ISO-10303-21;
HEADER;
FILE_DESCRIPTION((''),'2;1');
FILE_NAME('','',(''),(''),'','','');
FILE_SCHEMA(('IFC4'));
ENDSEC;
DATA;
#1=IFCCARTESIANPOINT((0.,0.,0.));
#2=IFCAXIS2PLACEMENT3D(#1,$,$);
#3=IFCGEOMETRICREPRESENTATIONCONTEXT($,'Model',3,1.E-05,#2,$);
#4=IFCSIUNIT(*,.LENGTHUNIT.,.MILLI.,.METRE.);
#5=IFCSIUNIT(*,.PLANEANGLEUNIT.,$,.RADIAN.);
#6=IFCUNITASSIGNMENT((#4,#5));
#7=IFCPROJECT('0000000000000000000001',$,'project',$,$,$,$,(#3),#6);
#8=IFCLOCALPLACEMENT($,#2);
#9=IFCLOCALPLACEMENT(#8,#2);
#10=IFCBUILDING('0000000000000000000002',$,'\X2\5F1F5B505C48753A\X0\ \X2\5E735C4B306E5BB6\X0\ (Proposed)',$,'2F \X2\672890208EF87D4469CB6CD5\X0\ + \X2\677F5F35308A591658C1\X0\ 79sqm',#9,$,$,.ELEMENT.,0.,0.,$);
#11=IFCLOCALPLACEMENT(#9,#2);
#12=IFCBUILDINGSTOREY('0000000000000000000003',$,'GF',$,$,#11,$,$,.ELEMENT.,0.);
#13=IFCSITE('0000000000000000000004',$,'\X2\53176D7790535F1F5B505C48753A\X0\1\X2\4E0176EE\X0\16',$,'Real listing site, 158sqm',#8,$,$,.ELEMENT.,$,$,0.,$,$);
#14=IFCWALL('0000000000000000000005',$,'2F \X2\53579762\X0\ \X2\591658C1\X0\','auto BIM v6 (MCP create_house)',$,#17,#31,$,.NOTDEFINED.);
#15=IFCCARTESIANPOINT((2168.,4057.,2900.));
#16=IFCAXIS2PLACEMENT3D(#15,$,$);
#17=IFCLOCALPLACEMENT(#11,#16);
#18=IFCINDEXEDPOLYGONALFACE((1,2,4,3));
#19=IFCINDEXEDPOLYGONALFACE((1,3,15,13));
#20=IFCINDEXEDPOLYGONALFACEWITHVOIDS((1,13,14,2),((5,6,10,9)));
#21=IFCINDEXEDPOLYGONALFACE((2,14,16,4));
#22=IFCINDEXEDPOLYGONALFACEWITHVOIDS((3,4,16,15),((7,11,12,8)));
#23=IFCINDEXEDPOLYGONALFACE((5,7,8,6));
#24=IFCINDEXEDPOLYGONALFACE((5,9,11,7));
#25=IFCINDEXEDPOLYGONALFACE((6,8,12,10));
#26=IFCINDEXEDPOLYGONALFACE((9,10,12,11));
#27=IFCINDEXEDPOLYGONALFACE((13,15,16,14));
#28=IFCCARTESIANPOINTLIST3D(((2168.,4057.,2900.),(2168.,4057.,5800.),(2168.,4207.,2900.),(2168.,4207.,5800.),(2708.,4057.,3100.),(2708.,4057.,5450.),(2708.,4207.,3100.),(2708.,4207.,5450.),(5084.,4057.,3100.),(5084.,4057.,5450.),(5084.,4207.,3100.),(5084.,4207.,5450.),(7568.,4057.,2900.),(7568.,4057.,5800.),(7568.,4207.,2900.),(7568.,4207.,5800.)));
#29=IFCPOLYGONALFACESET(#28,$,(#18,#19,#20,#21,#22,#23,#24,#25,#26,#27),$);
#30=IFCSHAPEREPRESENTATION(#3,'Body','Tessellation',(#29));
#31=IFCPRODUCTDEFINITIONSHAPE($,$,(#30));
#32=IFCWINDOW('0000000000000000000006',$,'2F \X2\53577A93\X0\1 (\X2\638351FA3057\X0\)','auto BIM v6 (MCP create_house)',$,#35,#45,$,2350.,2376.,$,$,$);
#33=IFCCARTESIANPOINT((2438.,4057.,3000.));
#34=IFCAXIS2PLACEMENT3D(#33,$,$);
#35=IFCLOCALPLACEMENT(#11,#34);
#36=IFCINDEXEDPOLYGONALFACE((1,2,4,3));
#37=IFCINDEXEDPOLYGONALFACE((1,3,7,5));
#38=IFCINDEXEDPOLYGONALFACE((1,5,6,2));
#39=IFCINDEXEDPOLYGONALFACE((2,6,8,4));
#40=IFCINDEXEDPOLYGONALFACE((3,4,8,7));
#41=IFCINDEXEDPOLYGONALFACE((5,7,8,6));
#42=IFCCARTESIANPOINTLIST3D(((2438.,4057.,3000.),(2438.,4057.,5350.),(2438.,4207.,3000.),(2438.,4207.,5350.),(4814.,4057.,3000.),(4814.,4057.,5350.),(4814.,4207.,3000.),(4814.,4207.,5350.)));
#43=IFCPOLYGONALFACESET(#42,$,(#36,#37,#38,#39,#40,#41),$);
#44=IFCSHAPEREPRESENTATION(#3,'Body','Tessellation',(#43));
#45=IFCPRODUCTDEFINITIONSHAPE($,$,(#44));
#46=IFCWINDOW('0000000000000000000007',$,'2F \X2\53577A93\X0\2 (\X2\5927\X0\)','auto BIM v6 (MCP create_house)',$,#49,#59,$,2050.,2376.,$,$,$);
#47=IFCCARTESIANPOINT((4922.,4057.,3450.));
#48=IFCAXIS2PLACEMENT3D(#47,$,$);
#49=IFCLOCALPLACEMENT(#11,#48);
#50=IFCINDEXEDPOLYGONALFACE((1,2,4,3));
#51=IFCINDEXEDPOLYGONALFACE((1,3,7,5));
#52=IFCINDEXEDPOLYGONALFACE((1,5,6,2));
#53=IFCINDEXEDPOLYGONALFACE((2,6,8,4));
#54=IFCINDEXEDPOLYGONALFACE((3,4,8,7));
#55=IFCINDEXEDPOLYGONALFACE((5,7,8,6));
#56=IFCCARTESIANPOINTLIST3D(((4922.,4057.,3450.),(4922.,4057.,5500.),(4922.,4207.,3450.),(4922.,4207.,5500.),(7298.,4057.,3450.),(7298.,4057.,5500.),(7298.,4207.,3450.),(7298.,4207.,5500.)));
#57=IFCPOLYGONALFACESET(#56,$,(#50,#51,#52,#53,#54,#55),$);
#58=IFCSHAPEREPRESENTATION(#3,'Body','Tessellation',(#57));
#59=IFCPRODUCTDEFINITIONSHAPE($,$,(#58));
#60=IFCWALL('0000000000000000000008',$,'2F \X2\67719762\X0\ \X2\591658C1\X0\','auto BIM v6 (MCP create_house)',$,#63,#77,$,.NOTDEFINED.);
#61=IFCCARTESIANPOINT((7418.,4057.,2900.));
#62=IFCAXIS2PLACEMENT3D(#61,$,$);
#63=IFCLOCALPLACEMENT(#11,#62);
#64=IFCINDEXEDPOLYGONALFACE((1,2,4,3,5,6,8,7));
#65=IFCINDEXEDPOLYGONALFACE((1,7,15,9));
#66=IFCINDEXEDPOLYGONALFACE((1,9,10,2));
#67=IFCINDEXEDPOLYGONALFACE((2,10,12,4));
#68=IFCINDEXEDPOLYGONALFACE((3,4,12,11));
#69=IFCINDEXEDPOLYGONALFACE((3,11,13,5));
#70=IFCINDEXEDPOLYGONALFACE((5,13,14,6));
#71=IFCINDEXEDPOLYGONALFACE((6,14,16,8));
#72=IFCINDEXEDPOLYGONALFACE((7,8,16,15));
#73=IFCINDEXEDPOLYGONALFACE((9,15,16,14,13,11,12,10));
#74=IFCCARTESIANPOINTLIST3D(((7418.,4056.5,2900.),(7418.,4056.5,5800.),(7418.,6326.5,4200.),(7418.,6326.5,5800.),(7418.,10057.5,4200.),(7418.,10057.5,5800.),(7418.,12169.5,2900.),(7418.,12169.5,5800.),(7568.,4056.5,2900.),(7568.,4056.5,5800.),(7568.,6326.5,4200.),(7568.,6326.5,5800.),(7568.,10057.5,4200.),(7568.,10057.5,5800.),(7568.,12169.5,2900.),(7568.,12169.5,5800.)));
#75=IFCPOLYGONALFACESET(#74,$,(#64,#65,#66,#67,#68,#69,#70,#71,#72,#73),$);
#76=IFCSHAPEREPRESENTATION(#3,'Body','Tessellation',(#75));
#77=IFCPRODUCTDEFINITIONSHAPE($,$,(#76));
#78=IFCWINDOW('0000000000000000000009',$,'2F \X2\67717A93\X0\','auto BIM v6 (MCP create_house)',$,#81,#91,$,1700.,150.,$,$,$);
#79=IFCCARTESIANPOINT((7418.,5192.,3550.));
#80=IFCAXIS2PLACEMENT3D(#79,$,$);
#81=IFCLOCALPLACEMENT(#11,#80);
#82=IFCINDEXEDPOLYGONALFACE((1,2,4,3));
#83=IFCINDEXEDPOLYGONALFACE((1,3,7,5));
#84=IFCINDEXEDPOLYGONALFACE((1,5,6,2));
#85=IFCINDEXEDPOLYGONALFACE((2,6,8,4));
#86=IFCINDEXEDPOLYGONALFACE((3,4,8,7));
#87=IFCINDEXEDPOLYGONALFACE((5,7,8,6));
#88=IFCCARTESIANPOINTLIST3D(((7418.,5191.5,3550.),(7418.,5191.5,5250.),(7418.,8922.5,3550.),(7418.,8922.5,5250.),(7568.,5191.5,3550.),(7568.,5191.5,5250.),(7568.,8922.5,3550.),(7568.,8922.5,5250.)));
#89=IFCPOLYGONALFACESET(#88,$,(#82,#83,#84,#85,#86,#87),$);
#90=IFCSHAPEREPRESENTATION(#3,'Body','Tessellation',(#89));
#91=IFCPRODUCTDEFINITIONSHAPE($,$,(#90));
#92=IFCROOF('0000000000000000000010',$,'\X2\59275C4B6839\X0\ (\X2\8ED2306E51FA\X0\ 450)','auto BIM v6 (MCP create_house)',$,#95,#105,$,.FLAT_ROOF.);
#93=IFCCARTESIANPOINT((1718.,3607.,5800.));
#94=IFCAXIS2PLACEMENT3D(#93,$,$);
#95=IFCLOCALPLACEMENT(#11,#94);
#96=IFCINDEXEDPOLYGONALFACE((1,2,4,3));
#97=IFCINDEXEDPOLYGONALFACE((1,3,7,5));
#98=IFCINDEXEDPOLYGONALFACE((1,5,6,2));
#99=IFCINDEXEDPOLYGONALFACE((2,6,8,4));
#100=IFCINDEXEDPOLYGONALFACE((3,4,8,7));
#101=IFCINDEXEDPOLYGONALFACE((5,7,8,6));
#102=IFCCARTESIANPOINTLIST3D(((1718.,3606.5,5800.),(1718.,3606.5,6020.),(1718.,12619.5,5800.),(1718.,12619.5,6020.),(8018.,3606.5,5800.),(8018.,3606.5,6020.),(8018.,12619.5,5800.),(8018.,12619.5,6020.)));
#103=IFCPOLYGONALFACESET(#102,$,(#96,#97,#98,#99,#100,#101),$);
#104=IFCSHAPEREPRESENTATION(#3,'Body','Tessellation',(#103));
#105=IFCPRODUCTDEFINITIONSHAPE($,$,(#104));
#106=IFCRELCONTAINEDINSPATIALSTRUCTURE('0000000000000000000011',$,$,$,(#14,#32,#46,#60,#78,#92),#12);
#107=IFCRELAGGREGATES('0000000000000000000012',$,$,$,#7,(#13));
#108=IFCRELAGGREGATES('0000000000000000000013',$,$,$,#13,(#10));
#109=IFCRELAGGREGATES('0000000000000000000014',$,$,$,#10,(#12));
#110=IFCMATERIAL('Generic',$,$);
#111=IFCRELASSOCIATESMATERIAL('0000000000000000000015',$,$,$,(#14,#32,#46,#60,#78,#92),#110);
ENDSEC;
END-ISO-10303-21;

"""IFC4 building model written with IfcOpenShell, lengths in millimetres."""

from ifc_helpers import new_model, si_unit, frame, frame_2d, origin, place, context, project, spatial, rectangle, extrude, material, element, fill, save


model = new_model("IFC4")

# Units and contexts
model_context = context("Model", 3, precision=1e-05, world=origin())
ifc_project = project(units=[si_unit("LENGTHUNIT", "METRE", prefix="MILLI"), si_unit("PLANEANGLEUNIT", "RADIAN")], contexts=[model_context])

# Site, building, storey
site_placement = place(None, origin())
site = spatial("IfcSite", under=ifc_project, at=site_placement, Name="北海道弟子屈町1丁目16", ObjectType="Real listing site, 158sqm", CompositionType="ELEMENT", RefElevation=0.0)
building_placement = place(site_placement, origin())
building = spatial("IfcBuilding", under=site, at=building_placement, Name="弟子屈町 平屋の家 (Proposed)", ObjectType="2F 木造軸組構法 + 板張り外壁 79sqm", CompositionType="ELEMENT", ElevationOfRefHeight=0.0, ElevationOfTerrain=0.0)
storey_placement = place(building_placement, origin())
storey = spatial("IfcBuildingStorey", under=building, at=storey_placement, Name="GF", CompositionType="ELEMENT", Elevation=0.0)

# Shared definitions
ifc_material = material(Name="Generic")

# Wall, openings, windows
wall_1_placement = place(storey_placement, frame((2168.0, 4057.0, 2900.0)))
wall_1 = element("IfcWall", 1, at=wall_1_placement, inside=storey, material=ifc_material, Name="2F 南面 外壁", Description="auto BIM v6 (MCP create_house)", PredefinedType="NOTDEFINED", context=model_context, shape_type="SweptSolid", body=[
    extrude(rectangle(XDim=5400.0, YDim=150.0, at=frame_2d((2700.0, 75.0))), frame((2168.0, 4057.0, 2900.0)), (0.0, 0.0, 1.0), 2900.0),
])
opening_1_placement = place(storey_placement, frame((2438.0, 4057.0, 3000.0)))
opening_1 = element("IfcOpeningElement", 2, at=opening_1_placement, cuts=wall_1, PredefinedType="NOTDEFINED", context=model_context, shape_type="SweptSolid", body=[
    extrude(rectangle(XDim=2376.0, YDim=150.0, at=frame_2d((1188.0, 75.0))), frame((2438.0, 4057.0, 3000.0)), (0.0, 0.0, 1.0), 2350.0),
])
opening_2_placement = place(storey_placement, frame((4922.0, 4057.0, 3450.0)))
opening_2 = element("IfcOpeningElement", 3, at=opening_2_placement, cuts=wall_1, PredefinedType="NOTDEFINED", context=model_context, shape_type="SweptSolid", body=[
    extrude(rectangle(XDim=2376.0, YDim=150.0, at=frame_2d((1188.0, 75.0))), frame((4922.0, 4057.0, 3450.0)), (0.0, 0.0, 1.0), 2050.0),
])
window_1_placement = place(storey_placement, frame((2438.0, 4057.0, 3000.0)))
window_1 = element("IfcWindow", 4, at=window_1_placement, inside=storey, material=ifc_material, Name="2F 南窓1 (掃出し)", Description="auto BIM v6 (MCP create_house)", OverallHeight=2350.0, OverallWidth=2376.0, context=model_context, shape_type="SweptSolid", body=[
    extrude(rectangle(XDim=2376.0, YDim=150.0, at=frame_2d((1188.0, 75.0))), frame((2438.0, 4057.0, 3000.0)), (0.0, 0.0, 1.0), 2350.0),
])
fill(opening_1, window_1)
window_2_placement = place(storey_placement, frame((4922.0, 4057.0, 3450.0)))
window_2 = element("IfcWindow", 5, at=window_2_placement, inside=storey, material=ifc_material, Name="2F 南窓2 (大)", Description="auto BIM v6 (MCP create_house)", OverallHeight=2050.0, OverallWidth=2376.0, context=model_context, shape_type="SweptSolid", body=[
    extrude(rectangle(XDim=2376.0, YDim=150.0, at=frame_2d((1188.0, 75.0))), frame((4922.0, 4057.0, 3450.0)), (0.0, 0.0, 1.0), 2050.0),
])
fill(opening_2, window_2)

# Wall, opening, window
wall_2_placement = place(storey_placement, frame((7418.0, 4057.0, 2900.0)))
wall_2 = element("IfcWall", 6, at=wall_2_placement, inside=storey, material=ifc_material, Name="2F 東面 外壁", Description="auto BIM v6 (MCP create_house)", PredefinedType="NOTDEFINED", context=model_context, shape_type="SweptSolid", body=[
    extrude(rectangle(XDim=150.0, YDim=8113.0, at=frame_2d((75.0, 4056.0))), frame((7418.0, 4057.0, 2900.0)), (0.0, 0.0, 1.0), 2900.0),
])
opening_3_placement = place(storey_placement, frame((7418.0, 5192.0, 3550.0)))
opening_3 = element("IfcOpeningElement", 7, at=opening_3_placement, cuts=wall_2, PredefinedType="NOTDEFINED", context=model_context, shape_type="SweptSolid", body=[
    extrude(rectangle(XDim=150.0, YDim=3731.0, at=frame_2d((75.0, 1865.0))), frame((7418.0, 5192.0, 3550.0)), (0.0, 0.0, 1.0), 1700.0),
])
window_3_placement = place(storey_placement, frame((7418.0, 5192.0, 3550.0)))
window_3 = element("IfcWindow", 8, at=window_3_placement, inside=storey, material=ifc_material, Name="2F 東窓", Description="auto BIM v6 (MCP create_house)", OverallHeight=1700.0, OverallWidth=150.0, context=model_context, shape_type="SweptSolid", body=[
    extrude(rectangle(XDim=150.0, YDim=3731.0, at=frame_2d((75.0, 1865.0))), frame((7418.0, 5192.0, 3550.0)), (0.0, 0.0, 1.0), 1700.0),
])
fill(opening_3, window_3)

# Roof
roof_placement = place(storey_placement, frame((1718.0, 3607.0, 5800.0)))
element("IfcRoof", 9, at=roof_placement, inside=storey, material=ifc_material, Name="大屋根 (軒の出 450)", Description="auto BIM v6 (MCP create_house)", PredefinedType="FLAT_ROOF", context=model_context, shape_type="SweptSolid", body=[
    extrude(rectangle(XDim=6300.0, YDim=9013.0, at=frame_2d((3150.0, 4506.0))), frame((1718.0, 3607.0, 5800.0)), (0.0, 0.0, 1.0), 220.0),
])

save(model, "model.ifc")
